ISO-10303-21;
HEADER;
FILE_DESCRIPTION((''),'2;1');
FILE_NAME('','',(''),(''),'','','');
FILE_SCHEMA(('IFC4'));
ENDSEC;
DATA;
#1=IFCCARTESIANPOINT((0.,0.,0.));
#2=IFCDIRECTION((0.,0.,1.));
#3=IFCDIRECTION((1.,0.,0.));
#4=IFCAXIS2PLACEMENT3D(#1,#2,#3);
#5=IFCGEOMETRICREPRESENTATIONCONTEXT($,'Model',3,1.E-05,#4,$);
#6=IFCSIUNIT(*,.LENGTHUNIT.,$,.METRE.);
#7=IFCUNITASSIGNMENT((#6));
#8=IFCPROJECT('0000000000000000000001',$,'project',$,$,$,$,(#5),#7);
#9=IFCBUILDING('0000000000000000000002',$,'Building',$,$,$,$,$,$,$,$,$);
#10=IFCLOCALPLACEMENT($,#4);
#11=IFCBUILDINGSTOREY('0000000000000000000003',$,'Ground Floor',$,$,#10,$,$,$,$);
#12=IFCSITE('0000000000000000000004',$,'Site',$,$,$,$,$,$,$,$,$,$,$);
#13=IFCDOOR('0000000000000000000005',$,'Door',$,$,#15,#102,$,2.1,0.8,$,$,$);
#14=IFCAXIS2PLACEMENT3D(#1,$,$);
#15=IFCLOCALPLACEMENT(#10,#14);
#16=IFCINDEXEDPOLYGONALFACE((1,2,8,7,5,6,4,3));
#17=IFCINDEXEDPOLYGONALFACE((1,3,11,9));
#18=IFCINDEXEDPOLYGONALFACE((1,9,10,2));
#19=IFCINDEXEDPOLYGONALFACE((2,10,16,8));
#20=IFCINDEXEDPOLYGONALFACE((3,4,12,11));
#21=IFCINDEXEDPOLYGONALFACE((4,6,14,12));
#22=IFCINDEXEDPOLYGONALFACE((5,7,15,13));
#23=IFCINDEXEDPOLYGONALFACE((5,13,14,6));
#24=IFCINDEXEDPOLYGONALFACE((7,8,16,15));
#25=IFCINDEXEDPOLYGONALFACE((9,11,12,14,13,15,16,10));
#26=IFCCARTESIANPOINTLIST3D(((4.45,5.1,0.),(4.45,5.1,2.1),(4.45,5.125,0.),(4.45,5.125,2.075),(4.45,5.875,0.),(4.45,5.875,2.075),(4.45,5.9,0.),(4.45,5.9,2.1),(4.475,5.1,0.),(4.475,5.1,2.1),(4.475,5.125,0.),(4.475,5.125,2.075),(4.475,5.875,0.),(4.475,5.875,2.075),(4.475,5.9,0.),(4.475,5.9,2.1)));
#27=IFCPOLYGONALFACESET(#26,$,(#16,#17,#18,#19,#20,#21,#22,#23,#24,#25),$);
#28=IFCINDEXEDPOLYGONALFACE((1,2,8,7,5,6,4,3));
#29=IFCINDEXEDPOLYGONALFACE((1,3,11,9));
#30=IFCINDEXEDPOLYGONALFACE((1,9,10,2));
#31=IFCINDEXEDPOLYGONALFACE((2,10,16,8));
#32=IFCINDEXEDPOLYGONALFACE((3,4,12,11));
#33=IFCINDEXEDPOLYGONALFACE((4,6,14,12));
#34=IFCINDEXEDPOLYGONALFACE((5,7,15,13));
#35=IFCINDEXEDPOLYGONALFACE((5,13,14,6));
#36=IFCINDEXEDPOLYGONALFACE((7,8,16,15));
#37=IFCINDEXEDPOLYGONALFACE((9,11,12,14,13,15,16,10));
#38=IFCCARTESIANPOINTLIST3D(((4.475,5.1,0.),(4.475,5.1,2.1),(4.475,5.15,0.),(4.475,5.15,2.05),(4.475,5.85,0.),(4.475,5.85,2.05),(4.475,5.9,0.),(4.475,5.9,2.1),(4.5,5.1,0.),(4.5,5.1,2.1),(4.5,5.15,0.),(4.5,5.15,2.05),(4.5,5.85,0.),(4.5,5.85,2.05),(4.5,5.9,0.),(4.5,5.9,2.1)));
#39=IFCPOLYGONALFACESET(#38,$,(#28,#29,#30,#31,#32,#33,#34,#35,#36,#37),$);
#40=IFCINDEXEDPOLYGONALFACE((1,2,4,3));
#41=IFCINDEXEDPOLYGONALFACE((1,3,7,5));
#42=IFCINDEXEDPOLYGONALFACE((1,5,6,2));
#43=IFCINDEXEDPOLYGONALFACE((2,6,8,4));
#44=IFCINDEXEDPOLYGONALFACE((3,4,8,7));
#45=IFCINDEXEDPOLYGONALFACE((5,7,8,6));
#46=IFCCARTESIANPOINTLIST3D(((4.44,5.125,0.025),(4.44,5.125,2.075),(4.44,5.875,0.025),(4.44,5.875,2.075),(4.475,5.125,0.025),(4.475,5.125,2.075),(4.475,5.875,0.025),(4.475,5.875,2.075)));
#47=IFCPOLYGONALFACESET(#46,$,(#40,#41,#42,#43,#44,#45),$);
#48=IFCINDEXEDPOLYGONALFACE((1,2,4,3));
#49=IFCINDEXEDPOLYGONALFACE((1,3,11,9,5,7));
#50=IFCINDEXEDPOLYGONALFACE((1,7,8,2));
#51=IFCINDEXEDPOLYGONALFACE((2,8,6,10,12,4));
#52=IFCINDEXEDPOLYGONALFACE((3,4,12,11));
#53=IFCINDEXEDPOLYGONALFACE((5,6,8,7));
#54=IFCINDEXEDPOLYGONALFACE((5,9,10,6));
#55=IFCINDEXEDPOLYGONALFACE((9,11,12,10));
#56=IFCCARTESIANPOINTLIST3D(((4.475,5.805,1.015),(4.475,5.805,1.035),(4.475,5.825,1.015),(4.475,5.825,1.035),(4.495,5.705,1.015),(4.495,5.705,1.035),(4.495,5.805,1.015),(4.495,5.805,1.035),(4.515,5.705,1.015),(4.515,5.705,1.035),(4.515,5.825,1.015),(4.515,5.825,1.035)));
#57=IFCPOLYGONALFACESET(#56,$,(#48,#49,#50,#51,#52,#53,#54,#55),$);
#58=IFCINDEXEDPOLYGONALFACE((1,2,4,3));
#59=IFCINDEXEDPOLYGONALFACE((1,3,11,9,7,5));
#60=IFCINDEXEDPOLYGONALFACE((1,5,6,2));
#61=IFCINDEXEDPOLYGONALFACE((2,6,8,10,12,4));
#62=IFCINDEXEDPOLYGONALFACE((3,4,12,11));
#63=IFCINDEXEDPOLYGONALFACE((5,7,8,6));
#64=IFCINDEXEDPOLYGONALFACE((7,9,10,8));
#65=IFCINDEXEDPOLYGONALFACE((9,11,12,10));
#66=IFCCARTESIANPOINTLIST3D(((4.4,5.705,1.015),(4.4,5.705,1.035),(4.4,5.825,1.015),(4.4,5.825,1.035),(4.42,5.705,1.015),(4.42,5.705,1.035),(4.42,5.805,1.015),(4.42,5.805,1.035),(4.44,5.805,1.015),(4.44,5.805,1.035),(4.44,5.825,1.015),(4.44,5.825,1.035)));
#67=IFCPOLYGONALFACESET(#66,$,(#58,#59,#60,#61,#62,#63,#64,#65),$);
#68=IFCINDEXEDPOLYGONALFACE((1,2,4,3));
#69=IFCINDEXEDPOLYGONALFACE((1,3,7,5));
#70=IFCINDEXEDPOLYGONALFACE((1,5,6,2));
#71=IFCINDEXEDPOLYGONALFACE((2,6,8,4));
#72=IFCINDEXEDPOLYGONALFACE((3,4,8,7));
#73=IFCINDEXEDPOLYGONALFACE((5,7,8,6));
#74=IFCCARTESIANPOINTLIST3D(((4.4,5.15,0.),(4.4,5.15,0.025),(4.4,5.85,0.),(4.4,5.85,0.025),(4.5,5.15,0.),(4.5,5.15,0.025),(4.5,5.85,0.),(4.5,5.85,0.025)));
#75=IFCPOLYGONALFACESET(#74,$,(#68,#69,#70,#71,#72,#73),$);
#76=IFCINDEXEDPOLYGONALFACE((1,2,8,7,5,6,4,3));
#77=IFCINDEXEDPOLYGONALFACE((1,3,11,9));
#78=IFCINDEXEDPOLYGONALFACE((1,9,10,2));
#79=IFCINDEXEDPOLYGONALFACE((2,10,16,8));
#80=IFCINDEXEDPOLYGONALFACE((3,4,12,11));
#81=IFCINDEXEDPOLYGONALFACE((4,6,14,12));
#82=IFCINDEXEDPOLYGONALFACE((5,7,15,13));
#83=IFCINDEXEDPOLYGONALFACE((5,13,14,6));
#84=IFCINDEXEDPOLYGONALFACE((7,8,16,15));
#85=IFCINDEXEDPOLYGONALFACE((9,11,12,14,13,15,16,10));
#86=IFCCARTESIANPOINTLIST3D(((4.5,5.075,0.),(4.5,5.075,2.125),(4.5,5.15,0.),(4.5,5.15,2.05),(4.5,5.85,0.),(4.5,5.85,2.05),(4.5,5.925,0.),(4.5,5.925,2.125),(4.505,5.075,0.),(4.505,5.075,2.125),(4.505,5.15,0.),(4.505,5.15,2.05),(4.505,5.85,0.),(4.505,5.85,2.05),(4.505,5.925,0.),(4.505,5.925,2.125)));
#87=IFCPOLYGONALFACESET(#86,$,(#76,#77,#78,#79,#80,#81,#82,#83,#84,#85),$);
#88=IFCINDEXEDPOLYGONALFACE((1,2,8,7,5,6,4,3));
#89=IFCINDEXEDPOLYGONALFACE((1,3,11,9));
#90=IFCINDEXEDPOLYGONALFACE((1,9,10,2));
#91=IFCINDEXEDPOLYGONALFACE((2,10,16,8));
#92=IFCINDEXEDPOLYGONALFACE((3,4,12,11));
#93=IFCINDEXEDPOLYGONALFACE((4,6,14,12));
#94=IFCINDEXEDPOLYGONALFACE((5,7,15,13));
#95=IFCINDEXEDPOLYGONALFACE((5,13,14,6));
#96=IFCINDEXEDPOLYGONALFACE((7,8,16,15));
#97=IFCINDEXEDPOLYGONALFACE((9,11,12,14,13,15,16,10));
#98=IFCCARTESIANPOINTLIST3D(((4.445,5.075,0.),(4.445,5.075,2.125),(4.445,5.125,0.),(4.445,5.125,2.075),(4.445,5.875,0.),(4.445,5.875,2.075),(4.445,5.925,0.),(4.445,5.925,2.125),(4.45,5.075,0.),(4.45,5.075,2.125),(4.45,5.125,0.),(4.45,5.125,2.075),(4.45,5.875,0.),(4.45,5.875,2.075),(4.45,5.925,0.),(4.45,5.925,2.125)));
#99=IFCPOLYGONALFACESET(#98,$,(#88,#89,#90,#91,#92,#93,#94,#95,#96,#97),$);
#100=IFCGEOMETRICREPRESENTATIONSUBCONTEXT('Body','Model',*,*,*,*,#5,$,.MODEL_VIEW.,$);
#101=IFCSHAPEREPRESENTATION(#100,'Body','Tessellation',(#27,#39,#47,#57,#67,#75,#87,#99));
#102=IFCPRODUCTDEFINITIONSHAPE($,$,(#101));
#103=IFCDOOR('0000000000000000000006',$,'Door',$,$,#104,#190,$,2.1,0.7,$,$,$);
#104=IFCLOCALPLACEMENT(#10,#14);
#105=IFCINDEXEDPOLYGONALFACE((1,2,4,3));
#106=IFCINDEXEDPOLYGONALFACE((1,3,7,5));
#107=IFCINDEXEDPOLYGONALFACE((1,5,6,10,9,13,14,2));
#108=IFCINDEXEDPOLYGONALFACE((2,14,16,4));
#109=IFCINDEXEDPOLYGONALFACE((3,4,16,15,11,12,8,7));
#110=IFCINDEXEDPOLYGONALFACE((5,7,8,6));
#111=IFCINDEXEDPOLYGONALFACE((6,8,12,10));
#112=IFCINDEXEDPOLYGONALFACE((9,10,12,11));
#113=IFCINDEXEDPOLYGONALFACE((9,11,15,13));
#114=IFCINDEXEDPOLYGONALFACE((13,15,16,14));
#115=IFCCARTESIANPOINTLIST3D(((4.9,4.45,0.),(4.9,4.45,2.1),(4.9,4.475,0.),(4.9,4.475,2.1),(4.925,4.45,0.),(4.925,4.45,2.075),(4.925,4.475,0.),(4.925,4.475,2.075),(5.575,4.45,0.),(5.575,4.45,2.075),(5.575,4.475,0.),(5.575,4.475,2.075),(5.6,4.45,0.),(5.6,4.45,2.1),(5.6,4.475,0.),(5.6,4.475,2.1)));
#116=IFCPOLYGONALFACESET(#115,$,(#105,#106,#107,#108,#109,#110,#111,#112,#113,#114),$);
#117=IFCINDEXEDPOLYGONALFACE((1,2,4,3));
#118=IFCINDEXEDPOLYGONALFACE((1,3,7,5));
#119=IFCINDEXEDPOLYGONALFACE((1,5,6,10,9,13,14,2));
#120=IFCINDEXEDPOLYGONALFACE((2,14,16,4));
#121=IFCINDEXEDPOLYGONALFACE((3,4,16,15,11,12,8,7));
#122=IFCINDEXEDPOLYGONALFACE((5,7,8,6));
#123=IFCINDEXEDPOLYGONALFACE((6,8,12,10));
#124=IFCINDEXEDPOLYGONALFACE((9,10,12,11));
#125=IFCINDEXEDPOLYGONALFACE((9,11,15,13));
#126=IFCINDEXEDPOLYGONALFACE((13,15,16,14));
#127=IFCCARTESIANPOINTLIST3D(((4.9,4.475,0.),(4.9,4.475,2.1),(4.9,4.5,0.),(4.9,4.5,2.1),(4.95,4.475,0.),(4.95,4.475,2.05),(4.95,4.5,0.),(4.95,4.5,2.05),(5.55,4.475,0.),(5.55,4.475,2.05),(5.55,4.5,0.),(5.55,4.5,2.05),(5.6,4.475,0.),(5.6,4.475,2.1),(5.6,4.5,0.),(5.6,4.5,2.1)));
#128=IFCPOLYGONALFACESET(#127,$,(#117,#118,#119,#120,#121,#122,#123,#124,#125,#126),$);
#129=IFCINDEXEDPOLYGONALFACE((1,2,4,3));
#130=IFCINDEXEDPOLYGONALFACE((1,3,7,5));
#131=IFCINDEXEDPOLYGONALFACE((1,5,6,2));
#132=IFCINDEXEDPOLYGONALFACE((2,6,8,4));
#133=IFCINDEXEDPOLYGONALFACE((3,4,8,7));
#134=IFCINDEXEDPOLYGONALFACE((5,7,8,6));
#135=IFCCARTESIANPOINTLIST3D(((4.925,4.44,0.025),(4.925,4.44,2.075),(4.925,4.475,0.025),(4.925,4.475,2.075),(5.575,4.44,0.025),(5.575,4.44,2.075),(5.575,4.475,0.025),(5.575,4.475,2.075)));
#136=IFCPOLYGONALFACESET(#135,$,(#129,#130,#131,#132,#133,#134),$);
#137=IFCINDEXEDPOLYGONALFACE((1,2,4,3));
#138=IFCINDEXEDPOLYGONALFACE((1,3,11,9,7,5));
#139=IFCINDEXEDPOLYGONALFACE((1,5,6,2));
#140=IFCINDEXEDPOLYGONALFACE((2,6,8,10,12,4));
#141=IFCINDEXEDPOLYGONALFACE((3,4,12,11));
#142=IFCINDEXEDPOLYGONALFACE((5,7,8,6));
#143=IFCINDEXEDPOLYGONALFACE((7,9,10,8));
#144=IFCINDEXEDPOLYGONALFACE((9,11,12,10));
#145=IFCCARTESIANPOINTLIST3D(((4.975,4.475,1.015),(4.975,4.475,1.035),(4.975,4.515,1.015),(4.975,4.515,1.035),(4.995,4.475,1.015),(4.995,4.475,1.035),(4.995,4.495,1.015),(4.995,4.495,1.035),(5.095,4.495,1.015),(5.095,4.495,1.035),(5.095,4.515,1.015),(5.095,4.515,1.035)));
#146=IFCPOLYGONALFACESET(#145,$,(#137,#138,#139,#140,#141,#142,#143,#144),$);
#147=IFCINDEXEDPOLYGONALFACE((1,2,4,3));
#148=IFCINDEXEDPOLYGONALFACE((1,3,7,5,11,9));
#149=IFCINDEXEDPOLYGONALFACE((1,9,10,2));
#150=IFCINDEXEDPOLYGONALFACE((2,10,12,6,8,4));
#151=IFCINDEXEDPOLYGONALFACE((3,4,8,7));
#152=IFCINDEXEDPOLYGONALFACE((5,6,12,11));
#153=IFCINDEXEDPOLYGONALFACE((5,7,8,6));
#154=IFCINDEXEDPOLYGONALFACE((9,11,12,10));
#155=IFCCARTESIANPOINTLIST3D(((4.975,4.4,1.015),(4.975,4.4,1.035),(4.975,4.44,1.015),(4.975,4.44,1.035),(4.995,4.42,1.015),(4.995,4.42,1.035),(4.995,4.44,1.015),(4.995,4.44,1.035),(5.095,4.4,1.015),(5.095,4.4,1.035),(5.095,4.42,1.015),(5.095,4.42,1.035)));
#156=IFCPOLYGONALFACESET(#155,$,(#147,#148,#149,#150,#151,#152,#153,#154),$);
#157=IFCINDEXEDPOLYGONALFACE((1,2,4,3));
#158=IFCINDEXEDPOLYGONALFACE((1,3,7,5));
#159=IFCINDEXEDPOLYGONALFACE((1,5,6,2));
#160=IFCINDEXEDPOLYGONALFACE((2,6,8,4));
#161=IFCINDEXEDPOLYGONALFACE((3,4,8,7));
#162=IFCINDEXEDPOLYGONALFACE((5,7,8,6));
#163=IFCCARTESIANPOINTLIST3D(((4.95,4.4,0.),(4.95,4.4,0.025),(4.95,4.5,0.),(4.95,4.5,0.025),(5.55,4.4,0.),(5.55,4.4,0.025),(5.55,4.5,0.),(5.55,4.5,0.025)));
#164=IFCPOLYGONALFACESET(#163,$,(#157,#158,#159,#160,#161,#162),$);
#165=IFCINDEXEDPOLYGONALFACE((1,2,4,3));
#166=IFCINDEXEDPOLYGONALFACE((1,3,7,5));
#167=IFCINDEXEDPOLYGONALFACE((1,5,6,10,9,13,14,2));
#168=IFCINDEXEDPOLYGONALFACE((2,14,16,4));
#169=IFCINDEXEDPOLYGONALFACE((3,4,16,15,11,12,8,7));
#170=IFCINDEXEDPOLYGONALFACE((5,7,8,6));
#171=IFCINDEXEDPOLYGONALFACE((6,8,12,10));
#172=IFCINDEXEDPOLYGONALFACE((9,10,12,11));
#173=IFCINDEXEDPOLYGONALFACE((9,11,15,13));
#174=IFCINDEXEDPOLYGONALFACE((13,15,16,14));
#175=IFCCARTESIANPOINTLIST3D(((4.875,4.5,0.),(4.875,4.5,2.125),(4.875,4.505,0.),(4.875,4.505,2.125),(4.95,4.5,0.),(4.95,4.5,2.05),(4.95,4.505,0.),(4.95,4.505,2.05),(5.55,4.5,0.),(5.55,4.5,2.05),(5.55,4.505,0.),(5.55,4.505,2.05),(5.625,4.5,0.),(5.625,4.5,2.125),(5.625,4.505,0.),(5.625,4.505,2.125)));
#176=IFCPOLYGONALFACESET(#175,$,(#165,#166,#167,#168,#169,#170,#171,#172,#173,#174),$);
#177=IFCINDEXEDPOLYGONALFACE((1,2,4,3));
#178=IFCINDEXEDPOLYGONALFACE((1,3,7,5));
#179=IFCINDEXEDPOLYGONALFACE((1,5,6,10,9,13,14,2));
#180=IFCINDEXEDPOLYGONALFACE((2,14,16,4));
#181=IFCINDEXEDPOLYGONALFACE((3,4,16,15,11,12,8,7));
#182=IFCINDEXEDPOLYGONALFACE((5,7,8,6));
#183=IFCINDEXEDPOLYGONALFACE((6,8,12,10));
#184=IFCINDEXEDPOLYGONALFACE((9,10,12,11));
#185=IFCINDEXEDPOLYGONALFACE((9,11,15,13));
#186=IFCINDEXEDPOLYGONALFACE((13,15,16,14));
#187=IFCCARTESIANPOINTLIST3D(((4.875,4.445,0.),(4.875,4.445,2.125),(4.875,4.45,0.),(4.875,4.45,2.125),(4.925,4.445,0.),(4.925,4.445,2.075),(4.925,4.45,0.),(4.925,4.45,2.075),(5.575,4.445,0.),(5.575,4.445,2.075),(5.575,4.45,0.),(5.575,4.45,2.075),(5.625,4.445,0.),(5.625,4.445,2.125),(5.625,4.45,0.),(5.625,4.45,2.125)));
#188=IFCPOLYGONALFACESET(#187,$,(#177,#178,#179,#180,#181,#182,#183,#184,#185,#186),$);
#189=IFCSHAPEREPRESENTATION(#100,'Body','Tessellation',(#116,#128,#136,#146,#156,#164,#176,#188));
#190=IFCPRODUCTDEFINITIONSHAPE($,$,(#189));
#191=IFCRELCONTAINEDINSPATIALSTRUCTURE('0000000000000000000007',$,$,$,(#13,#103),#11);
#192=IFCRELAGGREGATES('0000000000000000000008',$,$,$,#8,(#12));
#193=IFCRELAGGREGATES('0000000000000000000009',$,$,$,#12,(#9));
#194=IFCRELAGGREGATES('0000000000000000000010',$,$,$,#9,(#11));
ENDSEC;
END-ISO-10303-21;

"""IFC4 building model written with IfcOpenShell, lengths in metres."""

from ifc_helpers import new_model, si_unit, frame, origin_with_axes, place, context, subcontext, project, spatial, line, indexed_curve, outline, extrude, element, save


model = new_model("IFC4")

# Units and contexts
model_context = context("Model", 3, precision=1e-05, world=origin_with_axes())
body_context = subcontext(model_context, "Body", "Model", "MODEL_VIEW")
ifc_project = project(units=[si_unit("LENGTHUNIT", "METRE")], contexts=[model_context])

# Site, building, storey
site = spatial("IfcSite", under=ifc_project, Name="Site")
building = spatial("IfcBuilding", under=site, Name="Building")
storey_placement = place(None, origin_with_axes())
storey = spatial("IfcBuildingStorey", under=building, at=storey_placement, Name="Ground Floor")

# Doors
door_1_placement = place(storey_placement, frame((4.5, 5.1, 0.0), z_axis=(0.0, 0.0, 1.0), x_axis=(0.0, 1.0, 0.0)))
element("IfcDoor", 1, at=door_1_placement, inside=storey, Name="Door", OverallHeight=2.1, OverallWidth=0.8, context=body_context, shape_type="SweptSolid", body=[
    extrude(outline(indexed_curve([(0.0, 0.0), (0.0, 2.1), (0.8, 2.1), (0.8, 0.0), (0.775, 0.0), (0.775, 2.075), (0.025, 2.075), (0.025, 0.0)], segments=[line(1, 2, 3, 4, 5, 6, 7, 8, 1)])), frame((0.0, 0.025, 0.0), z_axis=(0.0, -1.0, 0.0), x_axis=(1.0, 0.0, 0.0)), (0.0, 0.0, -1.0), 0.025),
    extrude(outline(indexed_curve([(0.0, 0.0), (0.0, 2.1), (0.8, 2.1), (0.8, 0.0), (0.75, 0.0), (0.75, 2.05), (0.05, 2.05), (0.05, 0.0)], segments=[line(1, 2, 3, 4, 5, 6, 7, 8, 1)])), frame((0.0, 0.0, 0.0), z_axis=(0.0, -1.0, 0.0), x_axis=(1.0, 0.0, 0.0)), (0.0, 0.0, -1.0), 0.025),
    extrude(outline(indexed_curve([(0.0, 0.0), (0.75, 0.0), (0.75, 0.035), (0.0, 0.035)], segments=[line(1, 2, 3, 4, 1)])), frame((0.025, 0.025, 0.025), z_axis=(0.0, 0.0, 1.0), x_axis=(1.0, 0.0, 0.0)), (0.0, 0.0, 1.0), 2.05),
    extrude(outline(indexed_curve([(0.0, 0.0), (0.0, -0.04), (-0.12, -0.04), (-0.12, -0.02), (-0.02, -0.02), (-0.02, 0.0)], segments=[line(1, 2, 3, 4, 5, 6, 1)])), frame((0.725, 0.025, 1.015), z_axis=(0.0, 0.0, 1.0), x_axis=(1.0, 0.0, 0.0)), (0.0, 0.0, 1.0), 0.02),
    extrude(outline(indexed_curve([(0.0, 0.0), (0.0, 0.04), (-0.12, 0.04), (-0.12, 0.02), (-0.02, 0.02), (-0.02, 0.0)], segments=[line(1, 2, 3, 4, 5, 6, 1)])), frame((0.725, 0.06, 1.015), z_axis=(0.0, 0.0, 1.0), x_axis=(1.0, 0.0, 0.0)), (0.0, 0.0, 1.0), 0.02),
    extrude(outline(indexed_curve([(0.0, 0.0), (0.7, 0.0), (0.7, 0.1), (0.0, 0.1)], segments=[line(1, 2, 3, 4, 1)])), frame((0.05, 0.0, 0.0), z_axis=(0.0, 0.0, 1.0), x_axis=(1.0, 0.0, 0.0)), (0.0, 0.0, 1.0), 0.025),
    extrude(outline(indexed_curve([(0.0, 0.0), (0.0, 2.125), (0.85, 2.125), (0.85, 0.0), (0.775, 0.0), (0.775, 2.05), (0.075, 2.05), (0.075, 0.0)], segments=[line(1, 2, 3, 4, 5, 6, 7, 8, 1)])), frame((-0.025, -0.005, 0.0), z_axis=(0.0, -1.0, 0.0), x_axis=(1.0, 0.0, 0.0)), (0.0, 0.0, -1.0), 0.005),
    extrude(outline(indexed_curve([(0.0, 0.0), (0.0, 2.125), (0.85, 2.125), (0.85, 0.0), (0.8, 0.0), (0.8, 2.075), (0.05, 2.075), (0.05, 0.0)], segments=[line(1, 2, 3, 4, 5, 6, 7, 8, 1)])), frame((-0.025, 0.05, 0.0), z_axis=(0.0, -1.0, 0.0), x_axis=(1.0, 0.0, 0.0)), (0.0, 0.0, -1.0), 0.005),
])
door_2_placement = place(storey_placement, frame((5.6, 4.5, 0.0), z_axis=(0.0, 0.0, 1.0), x_axis=(-1.0, 0.0, 0.0)))
element("IfcDoor", 2, at=door_2_placement, inside=storey, Name="Door", OverallHeight=2.1, OverallWidth=0.7, context=body_context, shape_type="SweptSolid", body=[
    extrude(outline(indexed_curve([(0.0, 0.0), (0.0, 2.1), (0.7, 2.1), (0.7, 0.0), (0.675, 0.0), (0.675, 2.075), (0.025, 2.075), (0.025, 0.0)], segments=[line(1, 2, 3, 4, 5, 6, 7, 8, 1)])), frame((0.0, 0.025, 0.0), z_axis=(0.0, -1.0, 0.0), x_axis=(1.0, 0.0, 0.0)), (0.0, 0.0, -1.0), 0.025),
    extrude(outline(indexed_curve([(0.0, 0.0), (0.0, 2.1), (0.7, 2.1), (0.7, 0.0), (0.65, 0.0), (0.65, 2.05), (0.05, 2.05), (0.05, 0.0)], segments=[line(1, 2, 3, 4, 5, 6, 7, 8, 1)])), frame((0.0, 0.0, 0.0), z_axis=(0.0, -1.0, 0.0), x_axis=(1.0, 0.0, 0.0)), (0.0, 0.0, -1.0), 0.025),
    extrude(outline(indexed_curve([(0.0, 0.0), (0.65, 0.0), (0.65, 0.035), (0.0, 0.035)], segments=[line(1, 2, 3, 4, 1)])), frame((0.025, 0.025, 0.025), z_axis=(0.0, 0.0, 1.0), x_axis=(1.0, 0.0, 0.0)), (0.0, 0.0, 1.0), 2.05),
    extrude(outline(indexed_curve([(0.0, 0.0), (0.0, -0.04), (-0.12, -0.04), (-0.12, -0.02), (-0.02, -0.02), (-0.02, 0.0)], segments=[line(1, 2, 3, 4, 5, 6, 1)])), frame((0.625, 0.025, 1.015), z_axis=(0.0, 0.0, 1.0), x_axis=(1.0, 0.0, 0.0)), (0.0, 0.0, 1.0), 0.02),
    extrude(outline(indexed_curve([(0.0, 0.0), (0.0, 0.04), (-0.12, 0.04), (-0.12, 0.02), (-0.02, 0.02), (-0.02, 0.0)], segments=[line(1, 2, 3, 4, 5, 6, 1)])), frame((0.625, 0.06, 1.015), z_axis=(0.0, 0.0, 1.0), x_axis=(1.0, 0.0, 0.0)), (0.0, 0.0, 1.0), 0.02),
    extrude(outline(indexed_curve([(0.0, 0.0), (0.6, 0.0), (0.6, 0.1), (0.0, 0.1)], segments=[line(1, 2, 3, 4, 1)])), frame((0.05, 0.0, 0.0), z_axis=(0.0, 0.0, 1.0), x_axis=(1.0, 0.0, 0.0)), (0.0, 0.0, 1.0), 0.025),
    extrude(outline(indexed_curve([(0.0, 0.0), (0.0, 2.125), (0.75, 2.125), (0.75, 0.0), (0.675, 0.0), (0.675, 2.05), (0.075, 2.05), (0.075, 0.0)], segments=[line(1, 2, 3, 4, 5, 6, 7, 8, 1)])), frame((-0.025, -0.005, 0.0), z_axis=(0.0, -1.0, 0.0), x_axis=(1.0, 0.0, 0.0)), (0.0, 0.0, -1.0), 0.005),
    extrude(outline(indexed_curve([(0.0, 0.0), (0.0, 2.125), (0.75, 2.125), (0.75, 0.0), (0.7, 0.0), (0.7, 2.075), (0.05, 2.075), (0.05, 0.0)], segments=[line(1, 2, 3, 4, 5, 6, 7, 8, 1)])), frame((-0.025, 0.05, 0.0), z_axis=(0.0, -1.0, 0.0), x_axis=(1.0, 0.0, 0.0)), (0.0, 0.0, -1.0), 0.005),
])

save(model, "model.ifc")
